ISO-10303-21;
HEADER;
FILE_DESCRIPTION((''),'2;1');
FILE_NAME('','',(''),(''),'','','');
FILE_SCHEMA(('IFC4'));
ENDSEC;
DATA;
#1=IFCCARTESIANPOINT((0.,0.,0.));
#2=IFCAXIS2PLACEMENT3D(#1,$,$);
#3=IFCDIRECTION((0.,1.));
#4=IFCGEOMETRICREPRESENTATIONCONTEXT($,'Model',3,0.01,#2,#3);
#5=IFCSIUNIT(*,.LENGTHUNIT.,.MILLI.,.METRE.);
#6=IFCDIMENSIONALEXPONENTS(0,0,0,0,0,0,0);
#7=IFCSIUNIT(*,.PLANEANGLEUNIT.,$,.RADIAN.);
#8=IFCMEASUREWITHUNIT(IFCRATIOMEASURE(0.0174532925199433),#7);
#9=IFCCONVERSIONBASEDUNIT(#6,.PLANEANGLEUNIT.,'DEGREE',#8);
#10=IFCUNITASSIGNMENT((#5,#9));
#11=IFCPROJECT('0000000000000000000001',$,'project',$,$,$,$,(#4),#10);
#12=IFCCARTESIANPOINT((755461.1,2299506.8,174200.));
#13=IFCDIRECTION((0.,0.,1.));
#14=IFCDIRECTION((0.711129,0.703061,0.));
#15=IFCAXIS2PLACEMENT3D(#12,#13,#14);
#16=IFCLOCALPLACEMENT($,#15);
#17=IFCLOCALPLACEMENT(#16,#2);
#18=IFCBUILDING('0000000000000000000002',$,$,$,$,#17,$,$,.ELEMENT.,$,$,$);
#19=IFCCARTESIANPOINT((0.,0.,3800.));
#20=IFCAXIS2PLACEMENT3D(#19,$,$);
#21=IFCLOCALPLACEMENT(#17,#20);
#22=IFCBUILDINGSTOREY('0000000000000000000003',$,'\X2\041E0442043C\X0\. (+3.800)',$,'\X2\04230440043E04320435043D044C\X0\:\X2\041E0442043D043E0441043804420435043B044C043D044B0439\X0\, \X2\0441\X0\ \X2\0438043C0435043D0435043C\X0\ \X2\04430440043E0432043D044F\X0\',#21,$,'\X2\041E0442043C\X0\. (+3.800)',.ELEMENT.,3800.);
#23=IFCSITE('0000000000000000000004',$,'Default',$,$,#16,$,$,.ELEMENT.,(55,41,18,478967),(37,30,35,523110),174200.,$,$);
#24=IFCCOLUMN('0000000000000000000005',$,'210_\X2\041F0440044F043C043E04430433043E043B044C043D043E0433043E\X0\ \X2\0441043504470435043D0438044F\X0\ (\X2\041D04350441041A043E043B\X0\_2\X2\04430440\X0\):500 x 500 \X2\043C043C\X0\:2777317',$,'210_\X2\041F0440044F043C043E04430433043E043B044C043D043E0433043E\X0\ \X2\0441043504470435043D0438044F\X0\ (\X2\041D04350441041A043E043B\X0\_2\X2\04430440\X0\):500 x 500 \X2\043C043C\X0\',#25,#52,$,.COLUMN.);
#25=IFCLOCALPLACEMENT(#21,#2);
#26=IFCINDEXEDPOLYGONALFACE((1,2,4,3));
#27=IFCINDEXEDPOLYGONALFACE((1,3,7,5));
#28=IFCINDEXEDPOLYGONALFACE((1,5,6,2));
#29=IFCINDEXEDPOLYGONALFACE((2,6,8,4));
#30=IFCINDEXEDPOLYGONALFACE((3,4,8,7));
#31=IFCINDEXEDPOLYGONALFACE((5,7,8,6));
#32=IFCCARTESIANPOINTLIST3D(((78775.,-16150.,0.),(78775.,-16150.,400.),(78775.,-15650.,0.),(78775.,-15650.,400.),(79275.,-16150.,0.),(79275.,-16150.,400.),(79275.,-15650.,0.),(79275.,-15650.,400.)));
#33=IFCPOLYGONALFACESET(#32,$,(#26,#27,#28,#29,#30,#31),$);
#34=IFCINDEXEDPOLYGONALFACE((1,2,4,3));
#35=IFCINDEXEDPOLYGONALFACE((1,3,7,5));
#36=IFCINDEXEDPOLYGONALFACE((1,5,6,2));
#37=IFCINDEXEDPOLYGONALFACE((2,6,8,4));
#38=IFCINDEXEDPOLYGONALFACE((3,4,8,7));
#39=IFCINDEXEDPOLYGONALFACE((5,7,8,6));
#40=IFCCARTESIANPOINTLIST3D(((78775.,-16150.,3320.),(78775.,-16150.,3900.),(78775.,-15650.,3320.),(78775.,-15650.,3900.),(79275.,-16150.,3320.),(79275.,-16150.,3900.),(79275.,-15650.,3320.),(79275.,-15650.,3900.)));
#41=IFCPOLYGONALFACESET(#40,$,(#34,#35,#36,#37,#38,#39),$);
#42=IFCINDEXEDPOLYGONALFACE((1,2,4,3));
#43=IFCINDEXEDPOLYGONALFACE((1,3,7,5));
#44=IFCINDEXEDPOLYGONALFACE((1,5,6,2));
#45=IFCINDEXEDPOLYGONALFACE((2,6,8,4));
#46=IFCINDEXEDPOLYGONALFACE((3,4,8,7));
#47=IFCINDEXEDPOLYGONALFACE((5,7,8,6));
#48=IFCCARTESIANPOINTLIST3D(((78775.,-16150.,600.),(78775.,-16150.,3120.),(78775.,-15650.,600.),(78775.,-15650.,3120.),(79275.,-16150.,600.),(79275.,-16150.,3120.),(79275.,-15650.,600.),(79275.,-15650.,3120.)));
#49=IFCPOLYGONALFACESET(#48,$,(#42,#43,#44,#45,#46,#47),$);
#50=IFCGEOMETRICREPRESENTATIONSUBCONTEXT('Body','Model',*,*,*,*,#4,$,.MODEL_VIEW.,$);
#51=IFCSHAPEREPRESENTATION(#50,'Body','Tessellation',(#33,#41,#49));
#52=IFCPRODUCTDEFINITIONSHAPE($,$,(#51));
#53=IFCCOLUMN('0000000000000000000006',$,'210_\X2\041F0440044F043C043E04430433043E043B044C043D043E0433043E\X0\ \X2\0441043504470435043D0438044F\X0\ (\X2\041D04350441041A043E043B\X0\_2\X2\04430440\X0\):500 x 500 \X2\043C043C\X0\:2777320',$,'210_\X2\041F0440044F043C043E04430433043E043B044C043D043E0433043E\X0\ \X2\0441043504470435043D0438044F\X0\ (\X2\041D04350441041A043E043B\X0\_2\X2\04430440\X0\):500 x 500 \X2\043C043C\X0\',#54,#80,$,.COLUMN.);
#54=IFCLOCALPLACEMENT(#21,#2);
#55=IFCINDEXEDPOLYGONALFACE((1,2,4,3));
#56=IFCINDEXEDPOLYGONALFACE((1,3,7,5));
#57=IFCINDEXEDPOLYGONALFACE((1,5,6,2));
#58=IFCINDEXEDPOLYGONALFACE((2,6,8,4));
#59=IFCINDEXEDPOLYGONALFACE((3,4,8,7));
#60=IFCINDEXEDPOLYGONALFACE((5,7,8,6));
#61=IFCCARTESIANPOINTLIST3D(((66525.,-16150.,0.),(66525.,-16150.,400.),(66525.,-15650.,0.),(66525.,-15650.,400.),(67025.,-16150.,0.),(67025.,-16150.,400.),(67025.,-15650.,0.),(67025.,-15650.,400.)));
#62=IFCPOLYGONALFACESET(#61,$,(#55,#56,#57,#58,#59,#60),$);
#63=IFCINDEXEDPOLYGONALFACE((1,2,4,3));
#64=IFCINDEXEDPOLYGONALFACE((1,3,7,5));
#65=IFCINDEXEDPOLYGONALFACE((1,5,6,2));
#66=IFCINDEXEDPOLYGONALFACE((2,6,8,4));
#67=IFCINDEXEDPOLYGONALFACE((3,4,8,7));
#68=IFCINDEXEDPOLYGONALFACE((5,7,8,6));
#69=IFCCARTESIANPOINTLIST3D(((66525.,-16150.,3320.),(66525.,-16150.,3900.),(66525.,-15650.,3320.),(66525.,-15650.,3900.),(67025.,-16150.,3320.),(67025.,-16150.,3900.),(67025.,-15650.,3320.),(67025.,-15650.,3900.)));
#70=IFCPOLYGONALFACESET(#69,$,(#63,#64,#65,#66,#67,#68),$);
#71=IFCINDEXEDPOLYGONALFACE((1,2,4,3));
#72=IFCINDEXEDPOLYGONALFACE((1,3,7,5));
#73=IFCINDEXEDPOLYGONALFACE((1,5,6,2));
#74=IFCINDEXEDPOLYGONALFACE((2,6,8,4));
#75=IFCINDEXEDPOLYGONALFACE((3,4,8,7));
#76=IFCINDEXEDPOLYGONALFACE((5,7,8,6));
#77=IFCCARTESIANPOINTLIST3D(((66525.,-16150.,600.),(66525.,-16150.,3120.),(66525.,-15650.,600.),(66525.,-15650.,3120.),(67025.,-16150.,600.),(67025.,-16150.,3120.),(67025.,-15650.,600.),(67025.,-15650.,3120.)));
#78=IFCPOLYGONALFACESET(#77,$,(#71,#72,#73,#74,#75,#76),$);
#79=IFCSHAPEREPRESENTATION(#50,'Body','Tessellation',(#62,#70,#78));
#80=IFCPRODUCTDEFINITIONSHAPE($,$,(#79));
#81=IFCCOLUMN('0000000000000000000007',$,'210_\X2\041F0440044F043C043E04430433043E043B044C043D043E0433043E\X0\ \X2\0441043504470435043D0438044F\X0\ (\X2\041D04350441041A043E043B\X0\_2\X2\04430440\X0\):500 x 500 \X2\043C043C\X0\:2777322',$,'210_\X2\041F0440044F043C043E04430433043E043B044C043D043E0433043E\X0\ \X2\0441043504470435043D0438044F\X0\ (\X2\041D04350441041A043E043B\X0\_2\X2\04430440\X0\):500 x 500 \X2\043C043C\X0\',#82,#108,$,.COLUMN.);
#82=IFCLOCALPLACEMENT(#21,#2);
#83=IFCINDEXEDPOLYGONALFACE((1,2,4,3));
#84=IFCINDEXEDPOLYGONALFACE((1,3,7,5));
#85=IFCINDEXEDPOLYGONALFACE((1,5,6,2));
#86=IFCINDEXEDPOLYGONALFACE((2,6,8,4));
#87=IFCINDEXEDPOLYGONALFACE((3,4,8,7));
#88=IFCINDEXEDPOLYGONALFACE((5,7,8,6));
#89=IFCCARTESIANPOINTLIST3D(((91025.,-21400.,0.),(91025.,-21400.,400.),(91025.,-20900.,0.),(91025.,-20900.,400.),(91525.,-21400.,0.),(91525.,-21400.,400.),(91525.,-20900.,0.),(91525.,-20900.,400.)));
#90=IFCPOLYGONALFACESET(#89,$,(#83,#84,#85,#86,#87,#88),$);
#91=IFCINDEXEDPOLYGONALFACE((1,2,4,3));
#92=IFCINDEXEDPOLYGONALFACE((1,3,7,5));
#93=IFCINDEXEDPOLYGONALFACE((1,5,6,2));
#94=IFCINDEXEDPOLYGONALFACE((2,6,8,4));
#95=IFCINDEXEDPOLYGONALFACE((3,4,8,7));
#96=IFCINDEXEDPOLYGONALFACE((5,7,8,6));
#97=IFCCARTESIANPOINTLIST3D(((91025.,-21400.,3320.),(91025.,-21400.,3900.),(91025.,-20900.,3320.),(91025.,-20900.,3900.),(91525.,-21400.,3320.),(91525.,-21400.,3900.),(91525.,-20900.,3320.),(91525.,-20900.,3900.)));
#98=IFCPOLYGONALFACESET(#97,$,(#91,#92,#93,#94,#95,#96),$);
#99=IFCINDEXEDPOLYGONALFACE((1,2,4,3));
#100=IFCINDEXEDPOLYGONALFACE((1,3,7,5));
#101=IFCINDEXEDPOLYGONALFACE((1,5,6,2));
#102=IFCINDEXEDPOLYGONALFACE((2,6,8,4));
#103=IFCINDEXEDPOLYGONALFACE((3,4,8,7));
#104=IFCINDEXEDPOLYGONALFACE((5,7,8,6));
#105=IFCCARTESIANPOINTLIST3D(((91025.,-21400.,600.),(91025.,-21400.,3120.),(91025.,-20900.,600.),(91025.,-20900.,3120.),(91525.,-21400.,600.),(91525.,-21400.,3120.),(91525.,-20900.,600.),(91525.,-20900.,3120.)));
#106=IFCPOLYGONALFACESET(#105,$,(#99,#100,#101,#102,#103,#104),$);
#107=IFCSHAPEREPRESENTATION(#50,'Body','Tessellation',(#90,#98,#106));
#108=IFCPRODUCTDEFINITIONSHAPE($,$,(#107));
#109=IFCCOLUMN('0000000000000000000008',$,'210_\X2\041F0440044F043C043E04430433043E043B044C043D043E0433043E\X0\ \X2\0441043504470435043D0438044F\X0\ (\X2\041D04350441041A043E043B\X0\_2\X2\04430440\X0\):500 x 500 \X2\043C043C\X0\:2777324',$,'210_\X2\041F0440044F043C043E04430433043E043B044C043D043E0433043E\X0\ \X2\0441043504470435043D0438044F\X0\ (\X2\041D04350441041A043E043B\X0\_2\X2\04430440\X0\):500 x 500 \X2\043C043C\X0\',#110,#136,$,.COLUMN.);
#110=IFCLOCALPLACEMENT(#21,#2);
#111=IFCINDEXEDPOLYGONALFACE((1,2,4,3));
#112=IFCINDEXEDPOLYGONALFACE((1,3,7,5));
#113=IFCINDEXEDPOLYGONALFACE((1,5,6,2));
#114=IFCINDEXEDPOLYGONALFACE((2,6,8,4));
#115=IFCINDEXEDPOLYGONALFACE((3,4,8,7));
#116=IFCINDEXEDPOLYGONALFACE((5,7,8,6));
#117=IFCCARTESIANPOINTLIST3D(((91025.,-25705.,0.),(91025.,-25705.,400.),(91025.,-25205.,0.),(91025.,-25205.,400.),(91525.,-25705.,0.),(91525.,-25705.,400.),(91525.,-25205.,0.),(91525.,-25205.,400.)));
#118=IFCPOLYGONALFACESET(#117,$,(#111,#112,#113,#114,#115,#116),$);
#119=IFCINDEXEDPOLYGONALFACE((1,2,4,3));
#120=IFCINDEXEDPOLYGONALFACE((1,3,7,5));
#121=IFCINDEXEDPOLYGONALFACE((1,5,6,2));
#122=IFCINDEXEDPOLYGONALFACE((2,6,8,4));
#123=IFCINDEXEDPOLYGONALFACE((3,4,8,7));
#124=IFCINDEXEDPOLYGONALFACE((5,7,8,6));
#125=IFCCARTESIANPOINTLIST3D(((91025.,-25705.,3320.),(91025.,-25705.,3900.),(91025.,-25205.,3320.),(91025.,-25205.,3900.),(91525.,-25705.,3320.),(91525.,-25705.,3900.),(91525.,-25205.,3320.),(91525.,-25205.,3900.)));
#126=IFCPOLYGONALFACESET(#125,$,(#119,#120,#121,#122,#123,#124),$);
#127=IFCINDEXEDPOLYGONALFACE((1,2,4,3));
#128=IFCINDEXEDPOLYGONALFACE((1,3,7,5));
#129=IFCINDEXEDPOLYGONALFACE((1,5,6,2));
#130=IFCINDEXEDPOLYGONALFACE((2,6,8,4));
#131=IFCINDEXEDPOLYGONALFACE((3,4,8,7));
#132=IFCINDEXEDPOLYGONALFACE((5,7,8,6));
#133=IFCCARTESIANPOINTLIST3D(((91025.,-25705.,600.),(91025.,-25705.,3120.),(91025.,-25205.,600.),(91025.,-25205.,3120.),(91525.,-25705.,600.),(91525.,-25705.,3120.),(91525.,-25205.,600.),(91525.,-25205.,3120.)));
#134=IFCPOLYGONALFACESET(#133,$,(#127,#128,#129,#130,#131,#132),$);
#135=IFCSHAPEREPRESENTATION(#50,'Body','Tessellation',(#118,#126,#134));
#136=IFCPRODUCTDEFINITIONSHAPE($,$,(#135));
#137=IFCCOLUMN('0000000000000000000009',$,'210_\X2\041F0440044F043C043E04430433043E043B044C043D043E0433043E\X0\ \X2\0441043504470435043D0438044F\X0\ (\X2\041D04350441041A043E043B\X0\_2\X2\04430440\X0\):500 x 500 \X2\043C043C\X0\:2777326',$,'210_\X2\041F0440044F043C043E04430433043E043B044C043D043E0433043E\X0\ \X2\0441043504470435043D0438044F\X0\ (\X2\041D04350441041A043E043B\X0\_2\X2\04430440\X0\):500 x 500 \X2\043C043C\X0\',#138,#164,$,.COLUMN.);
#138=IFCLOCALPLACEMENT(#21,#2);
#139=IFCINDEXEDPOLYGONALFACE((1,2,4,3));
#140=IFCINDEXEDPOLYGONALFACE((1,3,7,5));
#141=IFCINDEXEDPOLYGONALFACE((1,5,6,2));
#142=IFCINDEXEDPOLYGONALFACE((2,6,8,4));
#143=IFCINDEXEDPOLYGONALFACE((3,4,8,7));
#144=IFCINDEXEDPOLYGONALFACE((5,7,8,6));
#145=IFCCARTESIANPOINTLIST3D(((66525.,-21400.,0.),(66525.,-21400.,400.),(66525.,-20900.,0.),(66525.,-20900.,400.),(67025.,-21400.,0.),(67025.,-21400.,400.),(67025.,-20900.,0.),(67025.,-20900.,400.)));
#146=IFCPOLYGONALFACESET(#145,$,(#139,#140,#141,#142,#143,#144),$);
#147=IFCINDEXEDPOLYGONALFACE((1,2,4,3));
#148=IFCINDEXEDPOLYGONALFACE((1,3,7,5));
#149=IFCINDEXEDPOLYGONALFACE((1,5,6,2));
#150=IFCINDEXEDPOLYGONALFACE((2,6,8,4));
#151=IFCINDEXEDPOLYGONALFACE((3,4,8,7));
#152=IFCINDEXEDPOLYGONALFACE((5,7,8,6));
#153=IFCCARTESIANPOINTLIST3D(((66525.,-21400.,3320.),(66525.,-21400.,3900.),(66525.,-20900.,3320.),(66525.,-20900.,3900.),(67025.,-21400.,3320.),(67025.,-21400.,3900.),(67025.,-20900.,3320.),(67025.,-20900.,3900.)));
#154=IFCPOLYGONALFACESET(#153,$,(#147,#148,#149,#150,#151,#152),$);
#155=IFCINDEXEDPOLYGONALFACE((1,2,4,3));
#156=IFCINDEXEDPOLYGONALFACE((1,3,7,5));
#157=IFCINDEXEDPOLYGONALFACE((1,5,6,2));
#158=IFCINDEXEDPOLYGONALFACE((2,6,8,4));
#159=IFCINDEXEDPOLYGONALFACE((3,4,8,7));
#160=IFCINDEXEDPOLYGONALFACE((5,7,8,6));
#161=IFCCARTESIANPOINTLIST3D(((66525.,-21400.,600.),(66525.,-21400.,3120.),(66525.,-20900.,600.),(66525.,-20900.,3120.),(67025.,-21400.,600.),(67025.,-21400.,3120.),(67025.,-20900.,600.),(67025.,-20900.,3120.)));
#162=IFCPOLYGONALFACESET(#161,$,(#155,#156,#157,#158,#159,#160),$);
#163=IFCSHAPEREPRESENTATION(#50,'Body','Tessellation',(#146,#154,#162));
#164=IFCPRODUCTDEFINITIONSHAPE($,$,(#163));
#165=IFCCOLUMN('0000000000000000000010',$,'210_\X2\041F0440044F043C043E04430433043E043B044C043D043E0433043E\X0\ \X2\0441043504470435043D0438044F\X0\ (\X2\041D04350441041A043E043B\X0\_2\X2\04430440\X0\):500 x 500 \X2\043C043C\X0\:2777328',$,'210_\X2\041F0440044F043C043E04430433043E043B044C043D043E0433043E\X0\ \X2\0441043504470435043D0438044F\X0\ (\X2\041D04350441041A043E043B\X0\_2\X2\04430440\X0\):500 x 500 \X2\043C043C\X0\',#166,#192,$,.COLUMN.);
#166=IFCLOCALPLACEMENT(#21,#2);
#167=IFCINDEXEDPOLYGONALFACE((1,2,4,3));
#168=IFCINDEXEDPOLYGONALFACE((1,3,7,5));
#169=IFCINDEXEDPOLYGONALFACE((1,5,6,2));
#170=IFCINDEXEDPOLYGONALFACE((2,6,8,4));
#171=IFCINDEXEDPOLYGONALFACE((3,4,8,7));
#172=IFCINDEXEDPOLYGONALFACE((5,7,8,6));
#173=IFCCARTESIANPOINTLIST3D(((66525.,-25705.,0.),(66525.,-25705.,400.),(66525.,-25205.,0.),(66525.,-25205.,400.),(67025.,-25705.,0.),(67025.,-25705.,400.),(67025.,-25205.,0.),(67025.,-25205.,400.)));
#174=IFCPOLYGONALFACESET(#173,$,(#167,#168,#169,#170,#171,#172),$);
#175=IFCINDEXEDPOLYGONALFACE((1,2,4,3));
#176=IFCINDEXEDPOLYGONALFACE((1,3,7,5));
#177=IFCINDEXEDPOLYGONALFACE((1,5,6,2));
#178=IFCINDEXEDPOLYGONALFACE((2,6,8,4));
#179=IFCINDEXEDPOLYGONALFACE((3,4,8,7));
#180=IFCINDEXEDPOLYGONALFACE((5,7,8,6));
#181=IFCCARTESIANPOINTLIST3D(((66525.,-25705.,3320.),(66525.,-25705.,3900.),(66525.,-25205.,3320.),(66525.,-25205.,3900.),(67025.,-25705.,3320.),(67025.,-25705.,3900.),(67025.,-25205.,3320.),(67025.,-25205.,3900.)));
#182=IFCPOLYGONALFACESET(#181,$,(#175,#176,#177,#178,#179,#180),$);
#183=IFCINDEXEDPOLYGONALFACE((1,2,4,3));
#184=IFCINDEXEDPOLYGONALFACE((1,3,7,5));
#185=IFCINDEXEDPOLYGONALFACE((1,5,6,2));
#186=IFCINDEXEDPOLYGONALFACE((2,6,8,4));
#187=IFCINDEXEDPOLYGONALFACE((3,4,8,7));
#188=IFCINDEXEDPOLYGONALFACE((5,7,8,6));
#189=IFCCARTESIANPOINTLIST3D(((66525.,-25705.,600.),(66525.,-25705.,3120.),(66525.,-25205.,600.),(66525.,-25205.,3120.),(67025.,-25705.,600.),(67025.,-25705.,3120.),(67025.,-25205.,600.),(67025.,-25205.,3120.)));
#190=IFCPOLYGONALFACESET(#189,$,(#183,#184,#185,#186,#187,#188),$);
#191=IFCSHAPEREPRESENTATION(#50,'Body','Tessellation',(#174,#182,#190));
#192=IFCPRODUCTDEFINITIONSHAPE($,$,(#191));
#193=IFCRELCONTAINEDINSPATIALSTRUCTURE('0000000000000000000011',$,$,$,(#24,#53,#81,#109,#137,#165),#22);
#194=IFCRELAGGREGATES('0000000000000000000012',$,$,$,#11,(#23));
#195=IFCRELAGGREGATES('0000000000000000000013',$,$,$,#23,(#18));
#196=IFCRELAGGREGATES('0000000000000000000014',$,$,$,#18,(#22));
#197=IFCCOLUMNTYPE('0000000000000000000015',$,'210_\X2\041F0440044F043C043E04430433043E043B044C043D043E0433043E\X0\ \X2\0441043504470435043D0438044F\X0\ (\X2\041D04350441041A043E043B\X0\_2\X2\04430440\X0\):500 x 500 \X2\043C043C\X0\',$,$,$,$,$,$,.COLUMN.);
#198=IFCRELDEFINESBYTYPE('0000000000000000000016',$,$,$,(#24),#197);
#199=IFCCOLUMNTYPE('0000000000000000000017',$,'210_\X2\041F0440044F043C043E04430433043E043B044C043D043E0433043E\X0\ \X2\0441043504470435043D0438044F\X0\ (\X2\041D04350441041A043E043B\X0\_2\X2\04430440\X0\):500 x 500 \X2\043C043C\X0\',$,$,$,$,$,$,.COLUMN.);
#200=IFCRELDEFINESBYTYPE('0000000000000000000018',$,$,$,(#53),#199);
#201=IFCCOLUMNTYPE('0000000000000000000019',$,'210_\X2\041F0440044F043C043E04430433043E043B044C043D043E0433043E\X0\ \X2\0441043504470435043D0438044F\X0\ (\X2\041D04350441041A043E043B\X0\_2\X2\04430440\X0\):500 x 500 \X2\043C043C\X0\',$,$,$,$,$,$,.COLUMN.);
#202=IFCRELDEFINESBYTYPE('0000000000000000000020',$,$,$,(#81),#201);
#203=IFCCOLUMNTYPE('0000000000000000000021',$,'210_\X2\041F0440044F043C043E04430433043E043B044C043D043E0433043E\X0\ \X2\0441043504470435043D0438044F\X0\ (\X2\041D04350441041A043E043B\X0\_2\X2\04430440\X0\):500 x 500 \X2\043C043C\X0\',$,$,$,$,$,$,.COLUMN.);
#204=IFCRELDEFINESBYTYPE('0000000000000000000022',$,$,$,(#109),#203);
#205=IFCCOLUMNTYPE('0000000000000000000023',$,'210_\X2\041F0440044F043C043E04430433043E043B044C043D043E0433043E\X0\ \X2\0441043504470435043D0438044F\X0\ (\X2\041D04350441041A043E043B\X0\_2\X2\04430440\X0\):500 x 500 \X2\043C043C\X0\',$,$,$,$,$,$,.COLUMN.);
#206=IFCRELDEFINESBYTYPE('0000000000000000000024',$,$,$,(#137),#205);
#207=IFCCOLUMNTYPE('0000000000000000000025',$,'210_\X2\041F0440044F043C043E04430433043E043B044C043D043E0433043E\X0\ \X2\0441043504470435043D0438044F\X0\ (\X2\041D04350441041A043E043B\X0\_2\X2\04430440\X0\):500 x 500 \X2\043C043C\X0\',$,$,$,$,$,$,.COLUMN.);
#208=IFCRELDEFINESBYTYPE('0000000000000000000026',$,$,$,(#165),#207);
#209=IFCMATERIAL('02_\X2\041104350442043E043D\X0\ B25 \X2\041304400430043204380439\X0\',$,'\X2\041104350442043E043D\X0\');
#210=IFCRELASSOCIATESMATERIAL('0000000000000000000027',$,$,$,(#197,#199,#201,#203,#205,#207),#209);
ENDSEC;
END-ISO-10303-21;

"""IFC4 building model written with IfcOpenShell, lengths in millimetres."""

from ifc_helpers import new_model, entity, si_unit, converted_unit, direction, frame, origin, place, context, subcontext, project, spatial, indexed_curve, outline, extrude, source, transform, mapped, material, type_object, type_shapes, element, save


model = new_model("IFC4")

# Units and contexts
model_context = context("Model", 3, precision=0.01, world=origin(), true_north=direction((0.0, 1.0)))
body_context = subcontext(model_context, "Body", "Model", "MODEL_VIEW")
ifc_project = project(units=[si_unit("LENGTHUNIT", "METRE", prefix="MILLI"), converted_unit("PLANEANGLEUNIT", "DEGREE", entity("IfcRatioMeasure", 0.0174532925199433), si_unit("PLANEANGLEUNIT", "RADIAN"), dimensions=[0, 0, 0, 0, 0, 0, 0])], contexts=[model_context])

# Site, building, storey
site_placement = place(None, frame((755461.1, 2299506.8, 174200.0), z_axis=(0.0, 0.0, 1.0), x_axis=(0.711129, 0.703061, 0.0)))
site = spatial("IfcSite", under=ifc_project, at=site_placement, Name="Default", CompositionType="ELEMENT", RefLatitude=(55, 41, 18, 478967), RefLongitude=(37, 30, 35, 523110), RefElevation=174200.0)
building_placement = place(site_placement, origin())
building = spatial("IfcBuilding", under=site, at=building_placement, CompositionType="ELEMENT")
storey_placement = place(building_placement, frame((0.0, 0.0, 3800.0)))
storey = spatial("IfcBuildingStorey", under=building, at=storey_placement, Name="Отм. (+3.800)", ObjectType="Уровень:Относительный, с именем уровня", LongName="Отм. (+3.800)", CompositionType="ELEMENT", Elevation=3800.0)

# Columns
ifc_material_1 = material(Name="02_Бетон B25 Гравий", Category="Бетон")
column_type_1 = type_object("IfcColumnType", Name="210_Прямоугольного сечения (НесКол_2ур):500 x 500 мм", PredefinedType="COLUMN", material=ifc_material_1)
shared_shape_1 = source(origin(), body_context, "Body", "SweptSolid", [
    extrude(outline(indexed_curve([(-250.0, -250.0), (250.0, -250.0), (250.0, 250.0), (-250.0, 250.0), (-250.0, -250.0)], self_intersect=False)), frame((79025.0, -15900.0, 3800.0), z_axis=(0.0, 0.0, 1.0), x_axis=(0.0, -1.0, 0.0)), (0.0, 0.0, 1.0), 400.0),
    extrude(outline(indexed_curve([(-250.0, -250.0), (250.0, -250.0), (250.0, 250.0), (-250.0, 250.0), (-250.0, -250.0)], self_intersect=False)), frame((79025.0, -15900.0, 7120.0), z_axis=(0.0, 0.0, 1.0), x_axis=(0.0, -1.0, 0.0)), (0.0, 0.0, 1.0), 580.0),
    extrude(outline(indexed_curve([(-250.0, -250.0), (250.0, -250.0), (250.0, 250.0), (-250.0, 250.0), (-250.0, -250.0)], self_intersect=False)), frame((79025.0, -15900.0, 4400.0), z_axis=(0.0, 0.0, 1.0), x_axis=(0.0, -1.0, 0.0)), (0.0, 0.0, 1.0), 2520.0),
])
type_shapes(column_type_1, [shared_shape_1])
column_1_placement = place(storey_placement, frame((0.0, 0.0, -3800.0)))
element("IfcColumn", 1, at=column_1_placement, inside=storey, type_object=column_type_1, Name="210_Прямоугольного сечения (НесКол_2ур):500 x 500 мм:2777317", ObjectType="210_Прямоугольного сечения (НесКол_2ур):500 x 500 мм", PredefinedType="COLUMN", context=body_context, shape_type="MappedRepresentation", body=[
    mapped(shared_shape_1, transform((0.0, 0.0, 0.0), scale=1.0)),
])
column_type_2 = type_object("IfcColumnType", Name="210_Прямоугольного сечения (НесКол_2ур):500 x 500 мм", PredefinedType="COLUMN", material=ifc_material_1)
shared_shape_2 = source(origin(), body_context, "Body", "SweptSolid", [
    extrude(outline(indexed_curve([(-250.0, -250.0), (250.0, -250.0), (250.0, 250.0), (-250.0, 250.0), (-250.0, -250.0)], self_intersect=False)), frame((66775.0, -15900.0, 3800.0), z_axis=(0.0, 0.0, 1.0), x_axis=(0.0, -1.0, 0.0)), (0.0, 0.0, 1.0), 400.0),
    extrude(outline(indexed_curve([(-250.0, -250.0), (250.0, -250.0), (250.0, 250.0), (-250.0, 250.0), (-250.0, -250.0)], self_intersect=False)), frame((66775.0, -15900.0, 7120.0), z_axis=(0.0, 0.0, 1.0), x_axis=(0.0, -1.0, 0.0)), (0.0, 0.0, 1.0), 580.0),
    extrude(outline(indexed_curve([(-250.0, -250.0), (250.0, -250.0), (250.0, 250.0), (-250.0, 250.0), (-250.0, -250.0)], self_intersect=False)), frame((66775.0, -15900.0, 4400.0), z_axis=(0.0, 0.0, 1.0), x_axis=(0.0, -1.0, 0.0)), (0.0, 0.0, 1.0), 2520.0),
])
type_shapes(column_type_2, [shared_shape_2])
column_2_placement = place(storey_placement, frame((0.0, 0.0, -3800.0)))
element("IfcColumn", 2, at=column_2_placement, inside=storey, type_object=column_type_2, Name="210_Прямоугольного сечения (НесКол_2ур):500 x 500 мм:2777320", ObjectType="210_Прямоугольного сечения (НесКол_2ур):500 x 500 мм", PredefinedType="COLUMN", context=body_context, shape_type="MappedRepresentation", body=[
    mapped(shared_shape_2, transform((0.0, 0.0, 0.0), scale=1.0)),
])
column_type_3 = type_object("IfcColumnType", Name="210_Прямоугольного сечения (НесКол_2ур):500 x 500 мм", PredefinedType="COLUMN", material=ifc_material_1)
shared_shape_3 = source(origin(), body_context, "Body", "SweptSolid", [
    extrude(outline(indexed_curve([(-250.0, -250.0), (250.0, -250.0), (250.0, 250.0), (-250.0, 250.0), (-250.0, -250.0)], self_intersect=False)), frame((91275.0, -21150.0, 3800.0), z_axis=(0.0, 0.0, 1.0), x_axis=(0.0, -1.0, 0.0)), (0.0, 0.0, 1.0), 400.0),
    extrude(outline(indexed_curve([(-250.0, -250.0), (250.0, -250.0), (250.0, 250.0), (-250.0, 250.0), (-250.0, -250.0)], self_intersect=False)), frame((91275.0, -21150.0, 7120.0), z_axis=(0.0, 0.0, 1.0), x_axis=(0.0, -1.0, 0.0)), (0.0, 0.0, 1.0), 580.0),
    extrude(outline(indexed_curve([(-250.0, -250.0), (250.0, -250.0), (250.0, 250.0), (-250.0, 250.0), (-250.0, -250.0)], self_intersect=False)), frame((91275.0, -21150.0, 4400.0), z_axis=(0.0, 0.0, 1.0), x_axis=(0.0, -1.0, 0.0)), (0.0, 0.0, 1.0), 2520.0),
])
type_shapes(column_type_3, [shared_shape_3])
column_3_placement = place(storey_placement, frame((0.0, 0.0, -3800.0)))
element("IfcColumn", 3, at=column_3_placement, inside=storey, type_object=column_type_3, Name="210_Прямоугольного сечения (НесКол_2ур):500 x 500 мм:2777322", ObjectType="210_Прямоугольного сечения (НесКол_2ур):500 x 500 мм", PredefinedType="COLUMN", context=body_context, shape_type="MappedRepresentation", body=[
    mapped(shared_shape_3, transform((0.0, 0.0, 0.0), scale=1.0)),
])
column_type_4 = type_object("IfcColumnType", Name="210_Прямоугольного сечения (НесКол_2ур):500 x 500 мм", PredefinedType="COLUMN", material=ifc_material_1)
shared_shape_4 = source(origin(), body_context, "Body", "SweptSolid", [
    extrude(outline(indexed_curve([(-250.0, -250.0), (250.0, -250.0), (250.0, 250.0), (-250.0, 250.0), (-250.0, -250.0)], self_intersect=False)), frame((91275.0, -25455.0, 3800.0), z_axis=(0.0, 0.0, 1.0), x_axis=(0.0, -1.0, 0.0)), (0.0, 0.0, 1.0), 400.0),
    extrude(outline(indexed_curve([(-250.0, -250.0), (250.0, -250.0), (250.0, 250.0), (-250.0, 250.0), (-250.0, -250.0)], self_intersect=False)), frame((91275.0, -25455.0, 7120.0), z_axis=(0.0, 0.0, 1.0), x_axis=(0.0, -1.0, 0.0)), (0.0, 0.0, 1.0), 580.0),
    extrude(outline(indexed_curve([(-250.0, -250.0), (250.0, -250.0), (250.0, 250.0), (-250.0, 250.0), (-250.0, -250.0)], self_intersect=False)), frame((91275.0, -25455.0, 4400.0), z_axis=(0.0, 0.0, 1.0), x_axis=(0.0, -1.0, 0.0)), (0.0, 0.0, 1.0), 2520.0),
])
type_shapes(column_type_4, [shared_shape_4])
column_4_placement = place(storey_placement, frame((0.0, 0.0, -3800.0)))
element("IfcColumn", 4, at=column_4_placement, inside=storey, type_object=column_type_4, Name="210_Прямоугольного сечения (НесКол_2ур):500 x 500 мм:2777324", ObjectType="210_Прямоугольного сечения (НесКол_2ур):500 x 500 мм", PredefinedType="COLUMN", context=body_context, shape_type="MappedRepresentation", body=[
    mapped(shared_shape_4, transform((0.0, 0.0, 0.0), scale=1.0)),
])
column_type_5 = type_object("IfcColumnType", Name="210_Прямоугольного сечения (НесКол_2ур):500 x 500 мм", PredefinedType="COLUMN", material=ifc_material_1)
shared_shape_5 = source(origin(), body_context, "Body", "SweptSolid", [
    extrude(outline(indexed_curve([(-250.0, -250.0), (250.0, -250.0), (250.0, 250.0), (-250.0, 250.0), (-250.0, -250.0)], self_intersect=False)), frame((66775.0, -21150.0, 3800.0), z_axis=(0.0, 0.0, 1.0), x_axis=(0.0, -1.0, 0.0)), (0.0, 0.0, 1.0), 400.0),
    extrude(outline(indexed_curve([(-250.0, -250.0), (250.0, -250.0), (250.0, 250.0), (-250.0, 250.0), (-250.0, -250.0)], self_intersect=False)), frame((66775.0, -21150.0, 7120.0), z_axis=(0.0, 0.0, 1.0), x_axis=(0.0, -1.0, 0.0)), (0.0, 0.0, 1.0), 580.0),
    extrude(outline(indexed_curve([(-250.0, -250.0), (250.0, -250.0), (250.0, 250.0), (-250.0, 250.0), (-250.0, -250.0)], self_intersect=False)), frame((66775.0, -21150.0, 4400.0), z_axis=(0.0, 0.0, 1.0), x_axis=(0.0, -1.0, 0.0)), (0.0, 0.0, 1.0), 2520.0),
])
type_shapes(column_type_5, [shared_shape_5])
column_5_placement = place(storey_placement, frame((0.0, 0.0, -3800.0)))
element("IfcColumn", 5, at=column_5_placement, inside=storey, type_object=column_type_5, Name="210_Прямоугольного сечения (НесКол_2ур):500 x 500 мм:2777326", ObjectType="210_Прямоугольного сечения (НесКол_2ур):500 x 500 мм", PredefinedType="COLUMN", context=body_context, shape_type="MappedRepresentation", body=[
    mapped(shared_shape_5, transform((0.0, 0.0, 0.0), scale=1.0)),
])
column_type_6 = type_object("IfcColumnType", Name="210_Прямоугольного сечения (НесКол_2ур):500 x 500 мм", PredefinedType="COLUMN", material=ifc_material_1)
shared_shape_6 = source(origin(), body_context, "Body", "SweptSolid", [
    extrude(outline(indexed_curve([(-250.0, -250.0), (250.0, -250.0), (250.0, 250.0), (-250.0, 250.0), (-250.0, -250.0)], self_intersect=False)), frame((66775.0, -25455.0, 3800.0), z_axis=(0.0, 0.0, 1.0), x_axis=(0.0, -1.0, 0.0)), (0.0, 0.0, 1.0), 400.0),
    extrude(outline(indexed_curve([(-250.0, -250.0), (250.0, -250.0), (250.0, 250.0), (-250.0, 250.0), (-250.0, -250.0)], self_intersect=False)), frame((66775.0, -25455.0, 7120.0), z_axis=(0.0, 0.0, 1.0), x_axis=(0.0, -1.0, 0.0)), (0.0, 0.0, 1.0), 580.0),
    extrude(outline(indexed_curve([(-250.0, -250.0), (250.0, -250.0), (250.0, 250.0), (-250.0, 250.0), (-250.0, -250.0)], self_intersect=False)), frame((66775.0, -25455.0, 4400.0), z_axis=(0.0, 0.0, 1.0), x_axis=(0.0, -1.0, 0.0)), (0.0, 0.0, 1.0), 2520.0),
])
type_shapes(column_type_6, [shared_shape_6])
column_6_placement = place(storey_placement, frame((0.0, 0.0, -3800.0)))
element("IfcColumn", 6, at=column_6_placement, inside=storey, type_object=column_type_6, Name="210_Прямоугольного сечения (НесКол_2ур):500 x 500 мм:2777328", ObjectType="210_Прямоугольного сечения (НесКол_2ур):500 x 500 мм", PredefinedType="COLUMN", context=body_context, shape_type="MappedRepresentation", body=[
    mapped(shared_shape_6, transform((0.0, 0.0, 0.0), scale=1.0)),
])

save(model, "model.ifc")
